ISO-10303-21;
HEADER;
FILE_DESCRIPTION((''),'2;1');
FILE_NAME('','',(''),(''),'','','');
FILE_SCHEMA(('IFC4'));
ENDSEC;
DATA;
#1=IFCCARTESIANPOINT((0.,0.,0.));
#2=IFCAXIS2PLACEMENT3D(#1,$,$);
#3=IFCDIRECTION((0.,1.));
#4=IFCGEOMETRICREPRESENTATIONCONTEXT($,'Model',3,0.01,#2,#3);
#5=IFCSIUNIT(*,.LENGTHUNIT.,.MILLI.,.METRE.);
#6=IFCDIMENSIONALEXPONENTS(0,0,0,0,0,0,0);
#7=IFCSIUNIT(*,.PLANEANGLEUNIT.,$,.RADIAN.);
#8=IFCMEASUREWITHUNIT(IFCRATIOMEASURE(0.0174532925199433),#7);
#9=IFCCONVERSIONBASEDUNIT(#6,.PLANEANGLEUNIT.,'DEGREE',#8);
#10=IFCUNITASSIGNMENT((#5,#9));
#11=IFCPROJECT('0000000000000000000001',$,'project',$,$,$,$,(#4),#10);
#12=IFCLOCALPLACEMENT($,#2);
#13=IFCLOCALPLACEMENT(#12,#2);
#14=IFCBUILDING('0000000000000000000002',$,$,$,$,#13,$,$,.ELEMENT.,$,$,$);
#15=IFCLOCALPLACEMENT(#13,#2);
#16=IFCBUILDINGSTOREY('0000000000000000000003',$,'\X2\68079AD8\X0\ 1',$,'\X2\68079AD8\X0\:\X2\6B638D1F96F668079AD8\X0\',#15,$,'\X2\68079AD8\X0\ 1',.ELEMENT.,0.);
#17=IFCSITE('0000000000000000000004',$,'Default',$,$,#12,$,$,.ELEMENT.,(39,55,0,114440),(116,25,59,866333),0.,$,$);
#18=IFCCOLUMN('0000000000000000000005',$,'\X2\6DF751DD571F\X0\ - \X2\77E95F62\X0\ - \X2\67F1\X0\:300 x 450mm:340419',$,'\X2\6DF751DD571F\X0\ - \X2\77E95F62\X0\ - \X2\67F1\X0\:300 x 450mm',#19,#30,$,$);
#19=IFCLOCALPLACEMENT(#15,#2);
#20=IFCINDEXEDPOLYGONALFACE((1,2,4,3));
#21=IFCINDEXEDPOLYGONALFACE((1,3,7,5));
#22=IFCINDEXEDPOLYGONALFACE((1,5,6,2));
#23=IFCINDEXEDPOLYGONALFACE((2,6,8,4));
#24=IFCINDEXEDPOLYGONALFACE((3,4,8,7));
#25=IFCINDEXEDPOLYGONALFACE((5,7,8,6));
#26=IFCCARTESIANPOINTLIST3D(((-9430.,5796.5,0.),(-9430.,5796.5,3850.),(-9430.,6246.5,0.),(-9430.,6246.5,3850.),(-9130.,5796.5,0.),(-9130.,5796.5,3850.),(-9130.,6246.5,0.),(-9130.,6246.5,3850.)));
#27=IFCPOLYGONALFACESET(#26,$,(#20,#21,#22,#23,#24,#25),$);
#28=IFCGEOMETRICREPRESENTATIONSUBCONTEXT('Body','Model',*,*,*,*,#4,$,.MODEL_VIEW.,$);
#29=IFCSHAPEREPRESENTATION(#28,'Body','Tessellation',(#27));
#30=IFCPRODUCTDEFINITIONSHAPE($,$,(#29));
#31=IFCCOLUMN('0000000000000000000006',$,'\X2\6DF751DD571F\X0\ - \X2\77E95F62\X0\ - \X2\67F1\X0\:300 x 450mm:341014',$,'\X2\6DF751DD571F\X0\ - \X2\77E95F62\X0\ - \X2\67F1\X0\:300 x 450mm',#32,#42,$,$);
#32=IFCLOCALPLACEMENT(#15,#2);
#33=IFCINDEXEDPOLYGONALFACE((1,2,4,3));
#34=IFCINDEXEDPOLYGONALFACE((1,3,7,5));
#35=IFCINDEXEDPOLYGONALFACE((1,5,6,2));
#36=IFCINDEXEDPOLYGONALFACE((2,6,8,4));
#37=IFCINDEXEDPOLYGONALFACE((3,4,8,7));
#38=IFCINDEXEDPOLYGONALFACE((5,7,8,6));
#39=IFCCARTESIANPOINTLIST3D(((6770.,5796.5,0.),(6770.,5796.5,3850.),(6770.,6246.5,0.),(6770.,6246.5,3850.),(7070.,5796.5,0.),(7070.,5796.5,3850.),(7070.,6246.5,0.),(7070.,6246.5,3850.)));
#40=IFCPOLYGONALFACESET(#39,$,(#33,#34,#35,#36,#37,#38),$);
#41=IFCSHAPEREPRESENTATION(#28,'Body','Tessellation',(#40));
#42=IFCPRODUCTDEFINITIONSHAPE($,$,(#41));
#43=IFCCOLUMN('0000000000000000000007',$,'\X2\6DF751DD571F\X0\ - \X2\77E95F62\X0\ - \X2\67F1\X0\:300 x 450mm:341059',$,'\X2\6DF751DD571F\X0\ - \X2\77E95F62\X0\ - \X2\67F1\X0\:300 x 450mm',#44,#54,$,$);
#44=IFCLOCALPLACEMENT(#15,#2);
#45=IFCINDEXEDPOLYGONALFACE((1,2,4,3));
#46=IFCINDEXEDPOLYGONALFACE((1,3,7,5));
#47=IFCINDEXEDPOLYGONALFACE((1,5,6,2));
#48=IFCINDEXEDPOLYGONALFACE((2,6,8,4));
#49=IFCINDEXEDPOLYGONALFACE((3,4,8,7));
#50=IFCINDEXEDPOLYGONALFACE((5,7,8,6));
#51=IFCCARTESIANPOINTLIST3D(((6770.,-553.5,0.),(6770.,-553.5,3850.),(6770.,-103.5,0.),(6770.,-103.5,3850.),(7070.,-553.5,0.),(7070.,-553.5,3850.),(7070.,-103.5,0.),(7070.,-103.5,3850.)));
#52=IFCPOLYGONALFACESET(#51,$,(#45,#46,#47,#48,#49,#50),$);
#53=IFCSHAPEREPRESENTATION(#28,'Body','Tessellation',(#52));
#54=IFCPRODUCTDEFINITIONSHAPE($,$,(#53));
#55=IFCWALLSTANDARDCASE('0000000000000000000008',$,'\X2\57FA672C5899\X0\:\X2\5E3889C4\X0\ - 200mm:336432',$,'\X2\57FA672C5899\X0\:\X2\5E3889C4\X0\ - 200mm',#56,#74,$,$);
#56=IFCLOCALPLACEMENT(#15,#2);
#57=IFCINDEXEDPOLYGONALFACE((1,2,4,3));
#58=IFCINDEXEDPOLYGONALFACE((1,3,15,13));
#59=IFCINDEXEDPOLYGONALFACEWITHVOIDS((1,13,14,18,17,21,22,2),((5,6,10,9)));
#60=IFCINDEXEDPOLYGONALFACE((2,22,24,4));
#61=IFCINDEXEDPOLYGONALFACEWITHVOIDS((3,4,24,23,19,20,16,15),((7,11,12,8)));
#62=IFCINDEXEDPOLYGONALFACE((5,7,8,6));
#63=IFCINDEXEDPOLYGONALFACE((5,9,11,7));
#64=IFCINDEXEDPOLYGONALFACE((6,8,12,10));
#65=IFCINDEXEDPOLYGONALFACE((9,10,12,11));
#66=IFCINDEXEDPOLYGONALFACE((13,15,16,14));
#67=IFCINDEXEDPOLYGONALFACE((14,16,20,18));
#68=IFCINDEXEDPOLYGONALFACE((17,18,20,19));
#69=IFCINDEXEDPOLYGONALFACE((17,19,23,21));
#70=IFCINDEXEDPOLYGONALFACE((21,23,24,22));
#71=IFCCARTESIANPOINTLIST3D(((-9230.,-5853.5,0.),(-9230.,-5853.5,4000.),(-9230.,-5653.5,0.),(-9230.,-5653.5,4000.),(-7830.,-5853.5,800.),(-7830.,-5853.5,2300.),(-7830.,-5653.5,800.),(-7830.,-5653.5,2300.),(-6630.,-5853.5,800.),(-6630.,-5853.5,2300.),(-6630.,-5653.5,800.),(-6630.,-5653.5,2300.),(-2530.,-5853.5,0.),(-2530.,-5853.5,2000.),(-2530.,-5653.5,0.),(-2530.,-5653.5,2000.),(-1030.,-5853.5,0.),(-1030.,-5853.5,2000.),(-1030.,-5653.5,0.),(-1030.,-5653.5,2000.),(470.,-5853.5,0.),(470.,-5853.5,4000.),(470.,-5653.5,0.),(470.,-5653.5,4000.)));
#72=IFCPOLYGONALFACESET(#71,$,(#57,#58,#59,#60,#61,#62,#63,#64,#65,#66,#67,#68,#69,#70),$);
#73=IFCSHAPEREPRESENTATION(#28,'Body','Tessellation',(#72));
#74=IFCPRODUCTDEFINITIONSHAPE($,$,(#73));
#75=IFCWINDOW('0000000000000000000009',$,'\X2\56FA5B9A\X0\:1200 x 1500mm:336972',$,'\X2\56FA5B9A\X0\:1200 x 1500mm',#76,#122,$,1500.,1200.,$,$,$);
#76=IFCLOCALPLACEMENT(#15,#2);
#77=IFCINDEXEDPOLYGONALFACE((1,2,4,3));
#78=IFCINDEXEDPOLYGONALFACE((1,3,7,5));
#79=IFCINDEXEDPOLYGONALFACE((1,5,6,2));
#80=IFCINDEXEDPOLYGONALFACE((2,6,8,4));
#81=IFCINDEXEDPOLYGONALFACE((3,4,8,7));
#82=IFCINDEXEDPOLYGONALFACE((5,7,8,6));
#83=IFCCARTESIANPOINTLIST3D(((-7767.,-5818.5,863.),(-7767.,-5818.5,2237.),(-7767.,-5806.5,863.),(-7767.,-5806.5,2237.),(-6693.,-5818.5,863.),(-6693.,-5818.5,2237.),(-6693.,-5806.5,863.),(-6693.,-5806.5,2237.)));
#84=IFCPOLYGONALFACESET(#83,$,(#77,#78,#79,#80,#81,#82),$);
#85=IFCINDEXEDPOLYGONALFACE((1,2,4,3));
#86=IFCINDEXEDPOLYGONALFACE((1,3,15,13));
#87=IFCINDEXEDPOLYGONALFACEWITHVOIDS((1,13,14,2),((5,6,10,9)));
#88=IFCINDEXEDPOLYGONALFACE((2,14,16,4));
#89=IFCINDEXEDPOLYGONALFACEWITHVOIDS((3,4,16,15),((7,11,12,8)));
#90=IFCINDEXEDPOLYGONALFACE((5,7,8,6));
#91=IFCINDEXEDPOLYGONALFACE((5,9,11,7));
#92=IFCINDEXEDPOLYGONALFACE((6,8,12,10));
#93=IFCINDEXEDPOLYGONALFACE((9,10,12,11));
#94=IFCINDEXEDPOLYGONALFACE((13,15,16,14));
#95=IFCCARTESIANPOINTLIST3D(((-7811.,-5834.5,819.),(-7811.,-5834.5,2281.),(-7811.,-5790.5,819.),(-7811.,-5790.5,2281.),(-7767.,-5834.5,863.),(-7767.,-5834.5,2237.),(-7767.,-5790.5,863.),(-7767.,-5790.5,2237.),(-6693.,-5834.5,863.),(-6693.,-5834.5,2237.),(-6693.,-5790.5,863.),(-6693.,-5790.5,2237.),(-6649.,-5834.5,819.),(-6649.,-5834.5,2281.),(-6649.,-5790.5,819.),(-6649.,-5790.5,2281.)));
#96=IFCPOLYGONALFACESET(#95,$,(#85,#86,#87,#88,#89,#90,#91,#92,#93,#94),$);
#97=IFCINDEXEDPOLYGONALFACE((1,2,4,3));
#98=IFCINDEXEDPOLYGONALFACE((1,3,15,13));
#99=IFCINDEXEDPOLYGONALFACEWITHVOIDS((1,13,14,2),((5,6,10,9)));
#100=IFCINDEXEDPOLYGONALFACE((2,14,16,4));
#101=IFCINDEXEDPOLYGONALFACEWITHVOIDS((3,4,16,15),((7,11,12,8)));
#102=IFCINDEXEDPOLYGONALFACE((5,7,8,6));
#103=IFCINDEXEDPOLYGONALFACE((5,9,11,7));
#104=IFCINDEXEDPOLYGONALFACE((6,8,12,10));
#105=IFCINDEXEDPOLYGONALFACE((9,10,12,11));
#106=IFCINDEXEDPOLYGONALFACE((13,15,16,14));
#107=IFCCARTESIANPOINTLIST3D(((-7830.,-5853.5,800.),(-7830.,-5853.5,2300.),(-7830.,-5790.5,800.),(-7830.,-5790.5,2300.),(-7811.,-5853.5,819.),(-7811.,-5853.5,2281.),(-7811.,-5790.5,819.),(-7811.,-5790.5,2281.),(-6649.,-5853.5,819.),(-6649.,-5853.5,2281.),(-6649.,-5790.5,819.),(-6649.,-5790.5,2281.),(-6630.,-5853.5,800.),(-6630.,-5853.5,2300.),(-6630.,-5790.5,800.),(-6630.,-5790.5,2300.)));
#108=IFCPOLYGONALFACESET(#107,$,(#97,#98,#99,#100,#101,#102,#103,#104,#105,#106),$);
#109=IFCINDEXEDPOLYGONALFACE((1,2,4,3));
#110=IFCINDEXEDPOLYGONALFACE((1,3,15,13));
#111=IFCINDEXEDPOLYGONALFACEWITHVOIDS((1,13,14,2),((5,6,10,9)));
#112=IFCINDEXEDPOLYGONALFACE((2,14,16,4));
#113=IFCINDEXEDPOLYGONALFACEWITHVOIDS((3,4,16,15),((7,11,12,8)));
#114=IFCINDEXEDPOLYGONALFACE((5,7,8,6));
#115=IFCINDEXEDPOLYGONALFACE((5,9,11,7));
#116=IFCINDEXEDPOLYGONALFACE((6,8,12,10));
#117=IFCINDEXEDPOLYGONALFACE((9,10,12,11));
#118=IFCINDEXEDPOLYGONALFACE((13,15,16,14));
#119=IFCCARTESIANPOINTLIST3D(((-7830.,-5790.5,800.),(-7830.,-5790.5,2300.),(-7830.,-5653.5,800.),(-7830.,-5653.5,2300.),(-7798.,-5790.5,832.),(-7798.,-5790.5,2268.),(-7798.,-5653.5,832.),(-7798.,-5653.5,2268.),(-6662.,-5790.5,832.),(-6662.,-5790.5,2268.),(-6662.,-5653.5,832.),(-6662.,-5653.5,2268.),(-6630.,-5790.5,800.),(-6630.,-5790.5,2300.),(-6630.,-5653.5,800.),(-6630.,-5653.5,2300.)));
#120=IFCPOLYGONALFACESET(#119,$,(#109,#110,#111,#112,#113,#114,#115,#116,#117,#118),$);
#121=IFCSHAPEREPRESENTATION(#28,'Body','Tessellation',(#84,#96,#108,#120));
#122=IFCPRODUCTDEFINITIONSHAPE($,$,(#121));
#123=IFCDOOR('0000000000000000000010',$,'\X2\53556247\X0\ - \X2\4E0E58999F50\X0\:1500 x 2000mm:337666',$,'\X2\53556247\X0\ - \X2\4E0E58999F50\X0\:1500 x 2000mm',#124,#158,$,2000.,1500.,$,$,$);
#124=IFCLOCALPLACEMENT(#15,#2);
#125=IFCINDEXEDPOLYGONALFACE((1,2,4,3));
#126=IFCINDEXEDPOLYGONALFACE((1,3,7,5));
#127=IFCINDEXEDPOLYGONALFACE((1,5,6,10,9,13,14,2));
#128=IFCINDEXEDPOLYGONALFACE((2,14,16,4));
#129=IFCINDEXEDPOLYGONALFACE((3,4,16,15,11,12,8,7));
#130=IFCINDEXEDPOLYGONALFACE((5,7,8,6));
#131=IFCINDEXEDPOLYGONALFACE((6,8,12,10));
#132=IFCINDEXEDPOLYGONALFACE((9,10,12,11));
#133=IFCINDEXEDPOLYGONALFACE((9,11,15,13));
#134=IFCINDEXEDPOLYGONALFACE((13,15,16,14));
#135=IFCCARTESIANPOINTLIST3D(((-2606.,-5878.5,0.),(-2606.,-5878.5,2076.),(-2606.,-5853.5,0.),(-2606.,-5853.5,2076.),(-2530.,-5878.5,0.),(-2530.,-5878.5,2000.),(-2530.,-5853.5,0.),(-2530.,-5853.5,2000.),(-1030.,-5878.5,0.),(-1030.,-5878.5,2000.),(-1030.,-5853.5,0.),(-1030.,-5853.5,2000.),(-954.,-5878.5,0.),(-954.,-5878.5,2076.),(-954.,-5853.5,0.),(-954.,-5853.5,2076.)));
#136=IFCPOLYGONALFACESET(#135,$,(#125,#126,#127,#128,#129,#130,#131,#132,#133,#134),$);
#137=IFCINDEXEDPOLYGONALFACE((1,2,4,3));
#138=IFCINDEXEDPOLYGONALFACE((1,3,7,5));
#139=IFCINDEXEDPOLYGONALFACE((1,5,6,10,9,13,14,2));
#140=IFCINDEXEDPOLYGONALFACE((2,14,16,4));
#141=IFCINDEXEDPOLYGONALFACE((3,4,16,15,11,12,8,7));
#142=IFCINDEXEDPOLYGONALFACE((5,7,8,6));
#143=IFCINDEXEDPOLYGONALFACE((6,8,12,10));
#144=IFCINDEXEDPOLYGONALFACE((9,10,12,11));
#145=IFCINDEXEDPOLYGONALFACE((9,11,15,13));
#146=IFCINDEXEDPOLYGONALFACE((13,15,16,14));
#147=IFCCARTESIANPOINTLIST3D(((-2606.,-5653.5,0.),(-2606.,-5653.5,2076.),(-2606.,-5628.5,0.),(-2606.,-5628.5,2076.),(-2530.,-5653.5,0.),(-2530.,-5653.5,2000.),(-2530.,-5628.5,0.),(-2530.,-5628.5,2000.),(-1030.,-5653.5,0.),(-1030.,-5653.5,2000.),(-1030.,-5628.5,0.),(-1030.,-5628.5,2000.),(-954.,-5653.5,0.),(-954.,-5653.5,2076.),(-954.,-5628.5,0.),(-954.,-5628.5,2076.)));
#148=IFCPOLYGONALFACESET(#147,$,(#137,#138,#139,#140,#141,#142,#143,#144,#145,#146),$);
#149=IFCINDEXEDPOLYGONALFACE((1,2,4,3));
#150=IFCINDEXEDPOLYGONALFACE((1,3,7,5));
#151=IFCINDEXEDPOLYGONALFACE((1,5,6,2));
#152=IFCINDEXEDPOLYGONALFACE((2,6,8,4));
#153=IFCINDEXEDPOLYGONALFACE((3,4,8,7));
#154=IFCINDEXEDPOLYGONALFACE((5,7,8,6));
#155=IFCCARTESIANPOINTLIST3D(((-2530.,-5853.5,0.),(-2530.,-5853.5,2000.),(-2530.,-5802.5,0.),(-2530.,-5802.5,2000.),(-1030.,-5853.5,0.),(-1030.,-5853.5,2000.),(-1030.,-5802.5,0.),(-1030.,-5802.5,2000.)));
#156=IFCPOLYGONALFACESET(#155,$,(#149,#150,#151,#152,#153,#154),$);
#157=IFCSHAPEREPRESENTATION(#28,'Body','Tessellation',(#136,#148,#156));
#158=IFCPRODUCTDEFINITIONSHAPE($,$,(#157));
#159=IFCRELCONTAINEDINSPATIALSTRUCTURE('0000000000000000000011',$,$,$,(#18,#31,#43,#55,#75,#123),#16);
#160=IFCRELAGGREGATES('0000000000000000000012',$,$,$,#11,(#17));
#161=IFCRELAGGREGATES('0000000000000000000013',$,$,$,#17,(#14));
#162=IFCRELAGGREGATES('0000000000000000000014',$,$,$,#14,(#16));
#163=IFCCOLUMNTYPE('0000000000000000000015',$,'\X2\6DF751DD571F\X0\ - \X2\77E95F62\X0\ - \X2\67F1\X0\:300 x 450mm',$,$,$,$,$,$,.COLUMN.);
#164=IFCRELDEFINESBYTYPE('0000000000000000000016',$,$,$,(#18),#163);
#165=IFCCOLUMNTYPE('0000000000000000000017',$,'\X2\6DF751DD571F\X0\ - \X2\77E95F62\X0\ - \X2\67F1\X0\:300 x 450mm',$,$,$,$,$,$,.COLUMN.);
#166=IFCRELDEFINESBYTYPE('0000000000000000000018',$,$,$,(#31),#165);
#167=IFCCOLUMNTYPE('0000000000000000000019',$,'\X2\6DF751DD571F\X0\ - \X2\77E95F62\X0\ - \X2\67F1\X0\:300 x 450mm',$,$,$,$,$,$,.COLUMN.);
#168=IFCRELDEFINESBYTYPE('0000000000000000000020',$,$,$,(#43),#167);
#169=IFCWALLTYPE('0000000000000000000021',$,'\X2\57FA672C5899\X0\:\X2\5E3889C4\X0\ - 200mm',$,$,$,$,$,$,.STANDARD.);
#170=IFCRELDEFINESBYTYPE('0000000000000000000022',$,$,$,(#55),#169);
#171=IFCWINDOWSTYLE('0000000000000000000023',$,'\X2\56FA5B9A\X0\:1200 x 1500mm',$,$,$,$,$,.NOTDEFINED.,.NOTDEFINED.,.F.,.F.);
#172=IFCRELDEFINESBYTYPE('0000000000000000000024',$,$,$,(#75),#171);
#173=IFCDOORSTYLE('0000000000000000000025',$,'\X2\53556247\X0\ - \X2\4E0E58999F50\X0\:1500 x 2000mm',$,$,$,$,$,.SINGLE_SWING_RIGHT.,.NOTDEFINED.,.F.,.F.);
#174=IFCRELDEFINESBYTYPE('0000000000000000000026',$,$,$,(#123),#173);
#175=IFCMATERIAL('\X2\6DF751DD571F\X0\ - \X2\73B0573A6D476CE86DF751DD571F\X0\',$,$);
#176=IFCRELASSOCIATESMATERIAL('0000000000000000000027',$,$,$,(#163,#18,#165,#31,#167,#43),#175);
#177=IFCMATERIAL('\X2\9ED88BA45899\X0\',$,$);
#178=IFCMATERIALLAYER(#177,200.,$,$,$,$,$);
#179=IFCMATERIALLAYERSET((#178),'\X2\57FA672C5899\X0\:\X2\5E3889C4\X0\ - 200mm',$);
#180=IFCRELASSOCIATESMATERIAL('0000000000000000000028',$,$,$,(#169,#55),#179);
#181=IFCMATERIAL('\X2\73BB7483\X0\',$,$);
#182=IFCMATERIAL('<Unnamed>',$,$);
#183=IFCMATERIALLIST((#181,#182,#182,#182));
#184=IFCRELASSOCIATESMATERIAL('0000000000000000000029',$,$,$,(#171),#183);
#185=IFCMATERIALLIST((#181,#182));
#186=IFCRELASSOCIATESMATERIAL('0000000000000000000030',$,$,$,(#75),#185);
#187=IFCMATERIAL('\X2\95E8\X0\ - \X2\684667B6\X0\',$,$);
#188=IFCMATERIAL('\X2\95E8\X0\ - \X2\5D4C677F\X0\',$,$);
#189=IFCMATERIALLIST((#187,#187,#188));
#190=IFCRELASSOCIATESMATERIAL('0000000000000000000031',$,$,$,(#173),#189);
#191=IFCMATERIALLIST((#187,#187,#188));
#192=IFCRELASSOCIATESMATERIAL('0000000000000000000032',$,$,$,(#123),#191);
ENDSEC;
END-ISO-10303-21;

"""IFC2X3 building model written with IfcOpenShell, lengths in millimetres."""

from ifc_helpers import new_model, entity, si_unit, converted_unit, direction, frame, frame_2d, origin, place, context, subcontext, project, spatial, polyline, rectangle, outline, extrude, source, transform, mapped, material, material_list, layer, layer_set, layer_usage, type_object, type_shapes, element, fill, save


model = new_model("IFC2X3")

# Units and contexts
model_context = context("Model", 3, precision=0.01, world=origin(), true_north=direction((0.0, 1.0)))
body_context = subcontext(model_context, "Body", "Model", "MODEL_VIEW")
ifc_project = project(units=[si_unit("LENGTHUNIT", "METRE", prefix="MILLI"), converted_unit("PLANEANGLEUNIT", "DEGREE", entity("IfcRatioMeasure", 0.0174532925199433), si_unit("PLANEANGLEUNIT", "RADIAN"), dimensions=[0, 0, 0, 0, 0, 0, 0])], contexts=[model_context])

# Site, building, storey
site_placement = place(None, origin())
site = spatial("IfcSite", under=ifc_project, at=site_placement, Name="Default", CompositionType="ELEMENT", RefLatitude=(39, 55, 0, 114440), RefLongitude=(116, 25, 59, 866333), RefElevation=0.0)
building_placement = place(site_placement, origin())
building = spatial("IfcBuilding", under=site, at=building_placement, CompositionType="ELEMENT")
storey_placement = place(building_placement, origin())
storey = spatial("IfcBuildingStorey", under=building, at=storey_placement, Name="标高 1", ObjectType="标高:正负零标高", LongName="标高 1", CompositionType="ELEMENT", Elevation=0.0)

# Columns
ifc_material_1 = material(Name="混凝土 - 现场浇注混凝土")
column_type_1 = type_object("IfcColumnType", Name="混凝土 - 矩形 - 柱:300 x 450mm", PredefinedType="COLUMN", material=ifc_material_1)
shared_shape_1 = source(origin(), body_context, "Body", "SweptSolid", [
    extrude(rectangle(XDim=450.0, YDim=300.0, at=frame_2d((0.0, 0.0), x_axis=(1.0, 0.0))), frame((-9280.0, 6021.5, 0.0), z_axis=(0.0, 0.0, 1.0), x_axis=(0.0, -1.0, 0.0)), (0.0, 0.0, 1.0), 3850.0),
])
type_shapes(column_type_1, [shared_shape_1])
column_1_placement = place(storey_placement, origin())
element("IfcColumn", 1, at=column_1_placement, inside=storey, type_object=column_type_1, material=ifc_material_1, Name="混凝土 - 矩形 - 柱:300 x 450mm:340419", ObjectType="混凝土 - 矩形 - 柱:300 x 450mm", context=body_context, shape_type="MappedRepresentation", body=[
    mapped(shared_shape_1, transform((0.0, 0.0, 0.0), scale=1.0)),
])
column_type_2 = type_object("IfcColumnType", Name="混凝土 - 矩形 - 柱:300 x 450mm", PredefinedType="COLUMN", material=ifc_material_1)
shared_shape_2 = source(origin(), body_context, "Body", "SweptSolid", [
    extrude(rectangle(XDim=450.0, YDim=300.0, at=frame_2d((0.0, 0.0), x_axis=(1.0, 0.0))), frame((6920.0, 6021.5, 0.0), z_axis=(0.0, 0.0, 1.0), x_axis=(0.0, -1.0, 0.0)), (0.0, 0.0, 1.0), 3850.0),
])
type_shapes(column_type_2, [shared_shape_2])
column_2_placement = place(storey_placement, origin())
element("IfcColumn", 2, at=column_2_placement, inside=storey, type_object=column_type_2, material=ifc_material_1, Name="混凝土 - 矩形 - 柱:300 x 450mm:341014", ObjectType="混凝土 - 矩形 - 柱:300 x 450mm", context=body_context, shape_type="MappedRepresentation", body=[
    mapped(shared_shape_2, transform((0.0, 0.0, 0.0), scale=1.0)),
])
column_type_3 = type_object("IfcColumnType", Name="混凝土 - 矩形 - 柱:300 x 450mm", PredefinedType="COLUMN", material=ifc_material_1)
shared_shape_3 = source(origin(), body_context, "Body", "SweptSolid", [
    extrude(rectangle(XDim=450.0, YDim=300.0, at=frame_2d((0.0, 0.0), x_axis=(1.0, 0.0))), frame((6920.0, -328.5, 0.0), z_axis=(0.0, 0.0, 1.0), x_axis=(0.0, -1.0, 0.0)), (0.0, 0.0, 1.0), 3850.0),
])
type_shapes(column_type_3, [shared_shape_3])
column_3_placement = place(storey_placement, origin())
element("IfcColumn", 3, at=column_3_placement, inside=storey, type_object=column_type_3, material=ifc_material_1, Name="混凝土 - 矩形 - 柱:300 x 450mm:341059", ObjectType="混凝土 - 矩形 - 柱:300 x 450mm", context=body_context, shape_type="MappedRepresentation", body=[
    mapped(shared_shape_3, transform((0.0, 0.0, 0.0), scale=1.0)),
])

# Shared definitions
ifc_material_2 = material(Name="默认墙")
ifc_layer = layer(ifc_material_2, 200.0)
ifc_layer_set = layer_set([ifc_layer], Name="基本墙:常规 - 200mm")
wall_type = type_object("IfcWallType", Name="基本墙:常规 - 200mm", PredefinedType="STANDARD", material=ifc_layer_set)
ifc_material_3 = material(Name="玻璃")
ifc_material_4 = material(Name="<Unnamed>")
ifc_material_list_1 = material_list([ifc_material_3, ifc_material_4, ifc_material_4, ifc_material_4])
window_style_1 = type_object("IfcWindowStyle", Name="固定:1200 x 1500mm", ConstructionType="NOTDEFINED", OperationType="NOTDEFINED", ParameterTakesPrecedence=False, Sizeable=False, material=ifc_material_list_1)
shared_shape_4 = source(origin(), body_context, "Body", "SweptSolid", [
    extrude(rectangle(XDim=12.0, YDim=1074.0, at=frame_2d((0.0, 0.0), x_axis=(1.0, 0.0))), frame((600.0, 159.0, 63.0), z_axis=(0.0, 0.0, 1.0), x_axis=(0.0, -1.0, 0.0)), (0.0, 0.0, 1.0), 1374.0),
    extrude(outline(polyline([(-581.0, -731.0), (581.0, -731.0), (581.0, 731.0), (-581.0, 731.0), (-581.0, -731.0)]), holes=[polyline([(-537.0, -687.0), (-537.0, 687.0), (537.0, 687.0), (537.0, -687.0), (-537.0, -687.0)])]), frame((600.0, 137.0, 750.0), z_axis=(0.0, 1.0, 0.0), x_axis=(1.0, 0.0, 0.0)), (0.0, 0.0, 1.0), 44.0),
    extrude(outline(polyline([(-600.0, -750.0), (600.0, -750.0), (600.0, 750.0), (-600.0, 750.0), (-600.0, -750.0)]), holes=[polyline([(-581.0, -731.0), (-581.0, 731.0), (581.0, 731.0), (581.0, -731.0), (-581.0, -731.0)])]), frame((600.0, 137.0, 750.0), z_axis=(0.0, 1.0, 0.0), x_axis=(1.0, 0.0, 0.0)), (0.0, 0.0, 1.0), 63.0),
    extrude(outline(polyline([(-600.0, -750.0), (600.0, -750.0), (600.0, 750.0), (-600.0, 750.0), (-600.0, -750.0)]), holes=[polyline([(-568.0, -718.0), (-568.0, 718.0), (568.0, 718.0), (568.0, -718.0), (-568.0, -718.0)])]), frame((600.0, 0.0, 750.0), z_axis=(0.0, 1.0, 0.0), x_axis=(1.0, 0.0, 0.0)), (0.0, 0.0, 1.0), 137.0),
])
type_shapes(window_style_1, [shared_shape_4])

# Wall, openings, window, door
ifc_layer_usage_1 = layer_usage(ifc_layer_set, "AXIS2", "NEGATIVE", 100.0)
wall_1_placement = place(storey_placement, frame((-9230.0, -5753.5, 0.0)))
wall_1 = element("IfcWallStandardCase", 4, at=wall_1_placement, inside=storey, type_object=wall_type, material=ifc_layer_usage_1, Name="基本墙:常规 - 200mm:336432", ObjectType="基本墙:常规 - 200mm", context=body_context, shape_type="SweptSolid", body=[
    extrude(rectangle(XDim=9700.0, YDim=200.0, at=frame_2d((4850.0, 0.0), x_axis=(-1.0, 0.0))), origin(), (0.0, 0.0, 1.0), 4000.0),
])
opening_1_placement = place(wall_1_placement, frame((8200.0, 100.0, 0.0)))
opening_1 = element("IfcOpeningElement", 5, at=opening_1_placement, cuts=wall_1, ObjectType="Opening", context=body_context, shape_type="SweptSolid", body=[
    extrude(rectangle(XDim=1500.0, YDim=2000.0, at=frame_2d((1000.0, 750.0), x_axis=(0.0, 1.0))), frame((0.0, 0.0, 0.0), z_axis=(0.0, -1.0, 0.0), x_axis=(0.0, 0.0, 1.0)), (0.0, 0.0, 1.0), 200.0),
])
opening_2_placement = place(wall_1_placement, frame((2600.0, 100.0, 800.0)))
opening_2 = element("IfcOpeningElement", 6, at=opening_2_placement, cuts=wall_1, ObjectType="Opening", context=body_context, shape_type="SweptSolid", body=[
    extrude(rectangle(XDim=1500.0, YDim=1200.0, at=frame_2d((750.0, 600.0), x_axis=(1.0, 0.0))), frame((0.0, 0.0, 0.0), z_axis=(0.0, -1.0, 0.0), x_axis=(0.0, 0.0, 1.0)), (0.0, 0.0, 1.0), 200.0),
])
ifc_material_list_2 = material_list([ifc_material_3, ifc_material_4])
window_1_placement = place(opening_2_placement, frame((0.0, 0.0, 0.0), z_axis=(0.0, 0.0, 1.0), x_axis=(-1.0, 0.0, 0.0)))
window_1 = element("IfcWindow", 7, at=window_1_placement, inside=storey, type_object=window_style_1, material=ifc_material_list_2, Name="固定:1200 x 1500mm:336972", ObjectType="固定:1200 x 1500mm", OverallHeight=1500.0, OverallWidth=1200.0, context=body_context, shape_type="MappedRepresentation", body=[
    mapped(shared_shape_4, transform((0.0, 0.0, 0.0), scale=1.0)),
])
fill(opening_2, window_1)
ifc_material_5 = material(Name="门 - 框架")
ifc_material_6 = material(Name="门 - 嵌板")
ifc_material_list_3 = material_list([ifc_material_5, ifc_material_5, ifc_material_6])
ifc_material_list_4 = material_list([ifc_material_5, ifc_material_5, ifc_material_6])
door_style_1 = type_object("IfcDoorStyle", Name="单扇 - 与墙齐:1500 x 2000mm", ConstructionType="NOTDEFINED", OperationType="SINGLE_SWING_RIGHT", ParameterTakesPrecedence=False, Sizeable=False, material=ifc_material_list_4)
shared_shape_5 = source(origin(), body_context, "Body", "SweptSolid", [
    extrude(outline(polyline([(-826.0, -1057.0), (826.0, -1057.0), (826.0, 1019.0), (750.0, 1019.0), (750.0, -981.0), (-750.0, -981.0), (-750.0, 1019.0), (-826.0, 1019.0), (-826.0, -1057.0)])), frame((750.0, 200.0, 1019.0), z_axis=(0.0, 1.0, 0.0), x_axis=(1.0, 0.0, 0.0)), (0.0, 0.0, 1.0), 25.0),
    extrude(outline(polyline([(-1057.0, -826.0), (1019.0, -826.0), (1019.0, -750.0), (-981.0, -750.0), (-981.0, 750.0), (1019.0, 750.0), (1019.0, 826.0), (-1057.0, 826.0), (-1057.0, -826.0)])), frame((750.0, -25.0, 1019.0), z_axis=(0.0, 1.0, 0.0), x_axis=(0.0, 0.0, -1.0)), (0.0, 0.0, 1.0), 25.0),
    extrude(rectangle(XDim=51.0, YDim=1500.0, at=frame_2d((0.0, 0.0), x_axis=(1.0, 0.0))), frame((750.0, 174.5, 0.0), z_axis=(0.0, 0.0, 1.0), x_axis=(0.0, 1.0, 0.0)), (0.0, 0.0, 1.0), 2000.0),
])
type_shapes(door_style_1, [shared_shape_5])
door_1_placement = place(opening_1_placement, frame((0.0, 0.0, 0.0), z_axis=(0.0, 0.0, 1.0), x_axis=(-1.0, 0.0, 0.0)))
door_1 = element("IfcDoor", 8, at=door_1_placement, inside=storey, type_object=door_style_1, material=ifc_material_list_3, Name="单扇 - 与墙齐:1500 x 2000mm:337666", ObjectType="单扇 - 与墙齐:1500 x 2000mm", OverallHeight=2000.0, OverallWidth=1500.0, context=body_context, shape_type="MappedRepresentation", body=[
    mapped(shared_shape_5, transform((0.0, 0.0, 0.0), scale=1.0)),
])
fill(opening_1, door_1)

save(model, "model.ifc")
